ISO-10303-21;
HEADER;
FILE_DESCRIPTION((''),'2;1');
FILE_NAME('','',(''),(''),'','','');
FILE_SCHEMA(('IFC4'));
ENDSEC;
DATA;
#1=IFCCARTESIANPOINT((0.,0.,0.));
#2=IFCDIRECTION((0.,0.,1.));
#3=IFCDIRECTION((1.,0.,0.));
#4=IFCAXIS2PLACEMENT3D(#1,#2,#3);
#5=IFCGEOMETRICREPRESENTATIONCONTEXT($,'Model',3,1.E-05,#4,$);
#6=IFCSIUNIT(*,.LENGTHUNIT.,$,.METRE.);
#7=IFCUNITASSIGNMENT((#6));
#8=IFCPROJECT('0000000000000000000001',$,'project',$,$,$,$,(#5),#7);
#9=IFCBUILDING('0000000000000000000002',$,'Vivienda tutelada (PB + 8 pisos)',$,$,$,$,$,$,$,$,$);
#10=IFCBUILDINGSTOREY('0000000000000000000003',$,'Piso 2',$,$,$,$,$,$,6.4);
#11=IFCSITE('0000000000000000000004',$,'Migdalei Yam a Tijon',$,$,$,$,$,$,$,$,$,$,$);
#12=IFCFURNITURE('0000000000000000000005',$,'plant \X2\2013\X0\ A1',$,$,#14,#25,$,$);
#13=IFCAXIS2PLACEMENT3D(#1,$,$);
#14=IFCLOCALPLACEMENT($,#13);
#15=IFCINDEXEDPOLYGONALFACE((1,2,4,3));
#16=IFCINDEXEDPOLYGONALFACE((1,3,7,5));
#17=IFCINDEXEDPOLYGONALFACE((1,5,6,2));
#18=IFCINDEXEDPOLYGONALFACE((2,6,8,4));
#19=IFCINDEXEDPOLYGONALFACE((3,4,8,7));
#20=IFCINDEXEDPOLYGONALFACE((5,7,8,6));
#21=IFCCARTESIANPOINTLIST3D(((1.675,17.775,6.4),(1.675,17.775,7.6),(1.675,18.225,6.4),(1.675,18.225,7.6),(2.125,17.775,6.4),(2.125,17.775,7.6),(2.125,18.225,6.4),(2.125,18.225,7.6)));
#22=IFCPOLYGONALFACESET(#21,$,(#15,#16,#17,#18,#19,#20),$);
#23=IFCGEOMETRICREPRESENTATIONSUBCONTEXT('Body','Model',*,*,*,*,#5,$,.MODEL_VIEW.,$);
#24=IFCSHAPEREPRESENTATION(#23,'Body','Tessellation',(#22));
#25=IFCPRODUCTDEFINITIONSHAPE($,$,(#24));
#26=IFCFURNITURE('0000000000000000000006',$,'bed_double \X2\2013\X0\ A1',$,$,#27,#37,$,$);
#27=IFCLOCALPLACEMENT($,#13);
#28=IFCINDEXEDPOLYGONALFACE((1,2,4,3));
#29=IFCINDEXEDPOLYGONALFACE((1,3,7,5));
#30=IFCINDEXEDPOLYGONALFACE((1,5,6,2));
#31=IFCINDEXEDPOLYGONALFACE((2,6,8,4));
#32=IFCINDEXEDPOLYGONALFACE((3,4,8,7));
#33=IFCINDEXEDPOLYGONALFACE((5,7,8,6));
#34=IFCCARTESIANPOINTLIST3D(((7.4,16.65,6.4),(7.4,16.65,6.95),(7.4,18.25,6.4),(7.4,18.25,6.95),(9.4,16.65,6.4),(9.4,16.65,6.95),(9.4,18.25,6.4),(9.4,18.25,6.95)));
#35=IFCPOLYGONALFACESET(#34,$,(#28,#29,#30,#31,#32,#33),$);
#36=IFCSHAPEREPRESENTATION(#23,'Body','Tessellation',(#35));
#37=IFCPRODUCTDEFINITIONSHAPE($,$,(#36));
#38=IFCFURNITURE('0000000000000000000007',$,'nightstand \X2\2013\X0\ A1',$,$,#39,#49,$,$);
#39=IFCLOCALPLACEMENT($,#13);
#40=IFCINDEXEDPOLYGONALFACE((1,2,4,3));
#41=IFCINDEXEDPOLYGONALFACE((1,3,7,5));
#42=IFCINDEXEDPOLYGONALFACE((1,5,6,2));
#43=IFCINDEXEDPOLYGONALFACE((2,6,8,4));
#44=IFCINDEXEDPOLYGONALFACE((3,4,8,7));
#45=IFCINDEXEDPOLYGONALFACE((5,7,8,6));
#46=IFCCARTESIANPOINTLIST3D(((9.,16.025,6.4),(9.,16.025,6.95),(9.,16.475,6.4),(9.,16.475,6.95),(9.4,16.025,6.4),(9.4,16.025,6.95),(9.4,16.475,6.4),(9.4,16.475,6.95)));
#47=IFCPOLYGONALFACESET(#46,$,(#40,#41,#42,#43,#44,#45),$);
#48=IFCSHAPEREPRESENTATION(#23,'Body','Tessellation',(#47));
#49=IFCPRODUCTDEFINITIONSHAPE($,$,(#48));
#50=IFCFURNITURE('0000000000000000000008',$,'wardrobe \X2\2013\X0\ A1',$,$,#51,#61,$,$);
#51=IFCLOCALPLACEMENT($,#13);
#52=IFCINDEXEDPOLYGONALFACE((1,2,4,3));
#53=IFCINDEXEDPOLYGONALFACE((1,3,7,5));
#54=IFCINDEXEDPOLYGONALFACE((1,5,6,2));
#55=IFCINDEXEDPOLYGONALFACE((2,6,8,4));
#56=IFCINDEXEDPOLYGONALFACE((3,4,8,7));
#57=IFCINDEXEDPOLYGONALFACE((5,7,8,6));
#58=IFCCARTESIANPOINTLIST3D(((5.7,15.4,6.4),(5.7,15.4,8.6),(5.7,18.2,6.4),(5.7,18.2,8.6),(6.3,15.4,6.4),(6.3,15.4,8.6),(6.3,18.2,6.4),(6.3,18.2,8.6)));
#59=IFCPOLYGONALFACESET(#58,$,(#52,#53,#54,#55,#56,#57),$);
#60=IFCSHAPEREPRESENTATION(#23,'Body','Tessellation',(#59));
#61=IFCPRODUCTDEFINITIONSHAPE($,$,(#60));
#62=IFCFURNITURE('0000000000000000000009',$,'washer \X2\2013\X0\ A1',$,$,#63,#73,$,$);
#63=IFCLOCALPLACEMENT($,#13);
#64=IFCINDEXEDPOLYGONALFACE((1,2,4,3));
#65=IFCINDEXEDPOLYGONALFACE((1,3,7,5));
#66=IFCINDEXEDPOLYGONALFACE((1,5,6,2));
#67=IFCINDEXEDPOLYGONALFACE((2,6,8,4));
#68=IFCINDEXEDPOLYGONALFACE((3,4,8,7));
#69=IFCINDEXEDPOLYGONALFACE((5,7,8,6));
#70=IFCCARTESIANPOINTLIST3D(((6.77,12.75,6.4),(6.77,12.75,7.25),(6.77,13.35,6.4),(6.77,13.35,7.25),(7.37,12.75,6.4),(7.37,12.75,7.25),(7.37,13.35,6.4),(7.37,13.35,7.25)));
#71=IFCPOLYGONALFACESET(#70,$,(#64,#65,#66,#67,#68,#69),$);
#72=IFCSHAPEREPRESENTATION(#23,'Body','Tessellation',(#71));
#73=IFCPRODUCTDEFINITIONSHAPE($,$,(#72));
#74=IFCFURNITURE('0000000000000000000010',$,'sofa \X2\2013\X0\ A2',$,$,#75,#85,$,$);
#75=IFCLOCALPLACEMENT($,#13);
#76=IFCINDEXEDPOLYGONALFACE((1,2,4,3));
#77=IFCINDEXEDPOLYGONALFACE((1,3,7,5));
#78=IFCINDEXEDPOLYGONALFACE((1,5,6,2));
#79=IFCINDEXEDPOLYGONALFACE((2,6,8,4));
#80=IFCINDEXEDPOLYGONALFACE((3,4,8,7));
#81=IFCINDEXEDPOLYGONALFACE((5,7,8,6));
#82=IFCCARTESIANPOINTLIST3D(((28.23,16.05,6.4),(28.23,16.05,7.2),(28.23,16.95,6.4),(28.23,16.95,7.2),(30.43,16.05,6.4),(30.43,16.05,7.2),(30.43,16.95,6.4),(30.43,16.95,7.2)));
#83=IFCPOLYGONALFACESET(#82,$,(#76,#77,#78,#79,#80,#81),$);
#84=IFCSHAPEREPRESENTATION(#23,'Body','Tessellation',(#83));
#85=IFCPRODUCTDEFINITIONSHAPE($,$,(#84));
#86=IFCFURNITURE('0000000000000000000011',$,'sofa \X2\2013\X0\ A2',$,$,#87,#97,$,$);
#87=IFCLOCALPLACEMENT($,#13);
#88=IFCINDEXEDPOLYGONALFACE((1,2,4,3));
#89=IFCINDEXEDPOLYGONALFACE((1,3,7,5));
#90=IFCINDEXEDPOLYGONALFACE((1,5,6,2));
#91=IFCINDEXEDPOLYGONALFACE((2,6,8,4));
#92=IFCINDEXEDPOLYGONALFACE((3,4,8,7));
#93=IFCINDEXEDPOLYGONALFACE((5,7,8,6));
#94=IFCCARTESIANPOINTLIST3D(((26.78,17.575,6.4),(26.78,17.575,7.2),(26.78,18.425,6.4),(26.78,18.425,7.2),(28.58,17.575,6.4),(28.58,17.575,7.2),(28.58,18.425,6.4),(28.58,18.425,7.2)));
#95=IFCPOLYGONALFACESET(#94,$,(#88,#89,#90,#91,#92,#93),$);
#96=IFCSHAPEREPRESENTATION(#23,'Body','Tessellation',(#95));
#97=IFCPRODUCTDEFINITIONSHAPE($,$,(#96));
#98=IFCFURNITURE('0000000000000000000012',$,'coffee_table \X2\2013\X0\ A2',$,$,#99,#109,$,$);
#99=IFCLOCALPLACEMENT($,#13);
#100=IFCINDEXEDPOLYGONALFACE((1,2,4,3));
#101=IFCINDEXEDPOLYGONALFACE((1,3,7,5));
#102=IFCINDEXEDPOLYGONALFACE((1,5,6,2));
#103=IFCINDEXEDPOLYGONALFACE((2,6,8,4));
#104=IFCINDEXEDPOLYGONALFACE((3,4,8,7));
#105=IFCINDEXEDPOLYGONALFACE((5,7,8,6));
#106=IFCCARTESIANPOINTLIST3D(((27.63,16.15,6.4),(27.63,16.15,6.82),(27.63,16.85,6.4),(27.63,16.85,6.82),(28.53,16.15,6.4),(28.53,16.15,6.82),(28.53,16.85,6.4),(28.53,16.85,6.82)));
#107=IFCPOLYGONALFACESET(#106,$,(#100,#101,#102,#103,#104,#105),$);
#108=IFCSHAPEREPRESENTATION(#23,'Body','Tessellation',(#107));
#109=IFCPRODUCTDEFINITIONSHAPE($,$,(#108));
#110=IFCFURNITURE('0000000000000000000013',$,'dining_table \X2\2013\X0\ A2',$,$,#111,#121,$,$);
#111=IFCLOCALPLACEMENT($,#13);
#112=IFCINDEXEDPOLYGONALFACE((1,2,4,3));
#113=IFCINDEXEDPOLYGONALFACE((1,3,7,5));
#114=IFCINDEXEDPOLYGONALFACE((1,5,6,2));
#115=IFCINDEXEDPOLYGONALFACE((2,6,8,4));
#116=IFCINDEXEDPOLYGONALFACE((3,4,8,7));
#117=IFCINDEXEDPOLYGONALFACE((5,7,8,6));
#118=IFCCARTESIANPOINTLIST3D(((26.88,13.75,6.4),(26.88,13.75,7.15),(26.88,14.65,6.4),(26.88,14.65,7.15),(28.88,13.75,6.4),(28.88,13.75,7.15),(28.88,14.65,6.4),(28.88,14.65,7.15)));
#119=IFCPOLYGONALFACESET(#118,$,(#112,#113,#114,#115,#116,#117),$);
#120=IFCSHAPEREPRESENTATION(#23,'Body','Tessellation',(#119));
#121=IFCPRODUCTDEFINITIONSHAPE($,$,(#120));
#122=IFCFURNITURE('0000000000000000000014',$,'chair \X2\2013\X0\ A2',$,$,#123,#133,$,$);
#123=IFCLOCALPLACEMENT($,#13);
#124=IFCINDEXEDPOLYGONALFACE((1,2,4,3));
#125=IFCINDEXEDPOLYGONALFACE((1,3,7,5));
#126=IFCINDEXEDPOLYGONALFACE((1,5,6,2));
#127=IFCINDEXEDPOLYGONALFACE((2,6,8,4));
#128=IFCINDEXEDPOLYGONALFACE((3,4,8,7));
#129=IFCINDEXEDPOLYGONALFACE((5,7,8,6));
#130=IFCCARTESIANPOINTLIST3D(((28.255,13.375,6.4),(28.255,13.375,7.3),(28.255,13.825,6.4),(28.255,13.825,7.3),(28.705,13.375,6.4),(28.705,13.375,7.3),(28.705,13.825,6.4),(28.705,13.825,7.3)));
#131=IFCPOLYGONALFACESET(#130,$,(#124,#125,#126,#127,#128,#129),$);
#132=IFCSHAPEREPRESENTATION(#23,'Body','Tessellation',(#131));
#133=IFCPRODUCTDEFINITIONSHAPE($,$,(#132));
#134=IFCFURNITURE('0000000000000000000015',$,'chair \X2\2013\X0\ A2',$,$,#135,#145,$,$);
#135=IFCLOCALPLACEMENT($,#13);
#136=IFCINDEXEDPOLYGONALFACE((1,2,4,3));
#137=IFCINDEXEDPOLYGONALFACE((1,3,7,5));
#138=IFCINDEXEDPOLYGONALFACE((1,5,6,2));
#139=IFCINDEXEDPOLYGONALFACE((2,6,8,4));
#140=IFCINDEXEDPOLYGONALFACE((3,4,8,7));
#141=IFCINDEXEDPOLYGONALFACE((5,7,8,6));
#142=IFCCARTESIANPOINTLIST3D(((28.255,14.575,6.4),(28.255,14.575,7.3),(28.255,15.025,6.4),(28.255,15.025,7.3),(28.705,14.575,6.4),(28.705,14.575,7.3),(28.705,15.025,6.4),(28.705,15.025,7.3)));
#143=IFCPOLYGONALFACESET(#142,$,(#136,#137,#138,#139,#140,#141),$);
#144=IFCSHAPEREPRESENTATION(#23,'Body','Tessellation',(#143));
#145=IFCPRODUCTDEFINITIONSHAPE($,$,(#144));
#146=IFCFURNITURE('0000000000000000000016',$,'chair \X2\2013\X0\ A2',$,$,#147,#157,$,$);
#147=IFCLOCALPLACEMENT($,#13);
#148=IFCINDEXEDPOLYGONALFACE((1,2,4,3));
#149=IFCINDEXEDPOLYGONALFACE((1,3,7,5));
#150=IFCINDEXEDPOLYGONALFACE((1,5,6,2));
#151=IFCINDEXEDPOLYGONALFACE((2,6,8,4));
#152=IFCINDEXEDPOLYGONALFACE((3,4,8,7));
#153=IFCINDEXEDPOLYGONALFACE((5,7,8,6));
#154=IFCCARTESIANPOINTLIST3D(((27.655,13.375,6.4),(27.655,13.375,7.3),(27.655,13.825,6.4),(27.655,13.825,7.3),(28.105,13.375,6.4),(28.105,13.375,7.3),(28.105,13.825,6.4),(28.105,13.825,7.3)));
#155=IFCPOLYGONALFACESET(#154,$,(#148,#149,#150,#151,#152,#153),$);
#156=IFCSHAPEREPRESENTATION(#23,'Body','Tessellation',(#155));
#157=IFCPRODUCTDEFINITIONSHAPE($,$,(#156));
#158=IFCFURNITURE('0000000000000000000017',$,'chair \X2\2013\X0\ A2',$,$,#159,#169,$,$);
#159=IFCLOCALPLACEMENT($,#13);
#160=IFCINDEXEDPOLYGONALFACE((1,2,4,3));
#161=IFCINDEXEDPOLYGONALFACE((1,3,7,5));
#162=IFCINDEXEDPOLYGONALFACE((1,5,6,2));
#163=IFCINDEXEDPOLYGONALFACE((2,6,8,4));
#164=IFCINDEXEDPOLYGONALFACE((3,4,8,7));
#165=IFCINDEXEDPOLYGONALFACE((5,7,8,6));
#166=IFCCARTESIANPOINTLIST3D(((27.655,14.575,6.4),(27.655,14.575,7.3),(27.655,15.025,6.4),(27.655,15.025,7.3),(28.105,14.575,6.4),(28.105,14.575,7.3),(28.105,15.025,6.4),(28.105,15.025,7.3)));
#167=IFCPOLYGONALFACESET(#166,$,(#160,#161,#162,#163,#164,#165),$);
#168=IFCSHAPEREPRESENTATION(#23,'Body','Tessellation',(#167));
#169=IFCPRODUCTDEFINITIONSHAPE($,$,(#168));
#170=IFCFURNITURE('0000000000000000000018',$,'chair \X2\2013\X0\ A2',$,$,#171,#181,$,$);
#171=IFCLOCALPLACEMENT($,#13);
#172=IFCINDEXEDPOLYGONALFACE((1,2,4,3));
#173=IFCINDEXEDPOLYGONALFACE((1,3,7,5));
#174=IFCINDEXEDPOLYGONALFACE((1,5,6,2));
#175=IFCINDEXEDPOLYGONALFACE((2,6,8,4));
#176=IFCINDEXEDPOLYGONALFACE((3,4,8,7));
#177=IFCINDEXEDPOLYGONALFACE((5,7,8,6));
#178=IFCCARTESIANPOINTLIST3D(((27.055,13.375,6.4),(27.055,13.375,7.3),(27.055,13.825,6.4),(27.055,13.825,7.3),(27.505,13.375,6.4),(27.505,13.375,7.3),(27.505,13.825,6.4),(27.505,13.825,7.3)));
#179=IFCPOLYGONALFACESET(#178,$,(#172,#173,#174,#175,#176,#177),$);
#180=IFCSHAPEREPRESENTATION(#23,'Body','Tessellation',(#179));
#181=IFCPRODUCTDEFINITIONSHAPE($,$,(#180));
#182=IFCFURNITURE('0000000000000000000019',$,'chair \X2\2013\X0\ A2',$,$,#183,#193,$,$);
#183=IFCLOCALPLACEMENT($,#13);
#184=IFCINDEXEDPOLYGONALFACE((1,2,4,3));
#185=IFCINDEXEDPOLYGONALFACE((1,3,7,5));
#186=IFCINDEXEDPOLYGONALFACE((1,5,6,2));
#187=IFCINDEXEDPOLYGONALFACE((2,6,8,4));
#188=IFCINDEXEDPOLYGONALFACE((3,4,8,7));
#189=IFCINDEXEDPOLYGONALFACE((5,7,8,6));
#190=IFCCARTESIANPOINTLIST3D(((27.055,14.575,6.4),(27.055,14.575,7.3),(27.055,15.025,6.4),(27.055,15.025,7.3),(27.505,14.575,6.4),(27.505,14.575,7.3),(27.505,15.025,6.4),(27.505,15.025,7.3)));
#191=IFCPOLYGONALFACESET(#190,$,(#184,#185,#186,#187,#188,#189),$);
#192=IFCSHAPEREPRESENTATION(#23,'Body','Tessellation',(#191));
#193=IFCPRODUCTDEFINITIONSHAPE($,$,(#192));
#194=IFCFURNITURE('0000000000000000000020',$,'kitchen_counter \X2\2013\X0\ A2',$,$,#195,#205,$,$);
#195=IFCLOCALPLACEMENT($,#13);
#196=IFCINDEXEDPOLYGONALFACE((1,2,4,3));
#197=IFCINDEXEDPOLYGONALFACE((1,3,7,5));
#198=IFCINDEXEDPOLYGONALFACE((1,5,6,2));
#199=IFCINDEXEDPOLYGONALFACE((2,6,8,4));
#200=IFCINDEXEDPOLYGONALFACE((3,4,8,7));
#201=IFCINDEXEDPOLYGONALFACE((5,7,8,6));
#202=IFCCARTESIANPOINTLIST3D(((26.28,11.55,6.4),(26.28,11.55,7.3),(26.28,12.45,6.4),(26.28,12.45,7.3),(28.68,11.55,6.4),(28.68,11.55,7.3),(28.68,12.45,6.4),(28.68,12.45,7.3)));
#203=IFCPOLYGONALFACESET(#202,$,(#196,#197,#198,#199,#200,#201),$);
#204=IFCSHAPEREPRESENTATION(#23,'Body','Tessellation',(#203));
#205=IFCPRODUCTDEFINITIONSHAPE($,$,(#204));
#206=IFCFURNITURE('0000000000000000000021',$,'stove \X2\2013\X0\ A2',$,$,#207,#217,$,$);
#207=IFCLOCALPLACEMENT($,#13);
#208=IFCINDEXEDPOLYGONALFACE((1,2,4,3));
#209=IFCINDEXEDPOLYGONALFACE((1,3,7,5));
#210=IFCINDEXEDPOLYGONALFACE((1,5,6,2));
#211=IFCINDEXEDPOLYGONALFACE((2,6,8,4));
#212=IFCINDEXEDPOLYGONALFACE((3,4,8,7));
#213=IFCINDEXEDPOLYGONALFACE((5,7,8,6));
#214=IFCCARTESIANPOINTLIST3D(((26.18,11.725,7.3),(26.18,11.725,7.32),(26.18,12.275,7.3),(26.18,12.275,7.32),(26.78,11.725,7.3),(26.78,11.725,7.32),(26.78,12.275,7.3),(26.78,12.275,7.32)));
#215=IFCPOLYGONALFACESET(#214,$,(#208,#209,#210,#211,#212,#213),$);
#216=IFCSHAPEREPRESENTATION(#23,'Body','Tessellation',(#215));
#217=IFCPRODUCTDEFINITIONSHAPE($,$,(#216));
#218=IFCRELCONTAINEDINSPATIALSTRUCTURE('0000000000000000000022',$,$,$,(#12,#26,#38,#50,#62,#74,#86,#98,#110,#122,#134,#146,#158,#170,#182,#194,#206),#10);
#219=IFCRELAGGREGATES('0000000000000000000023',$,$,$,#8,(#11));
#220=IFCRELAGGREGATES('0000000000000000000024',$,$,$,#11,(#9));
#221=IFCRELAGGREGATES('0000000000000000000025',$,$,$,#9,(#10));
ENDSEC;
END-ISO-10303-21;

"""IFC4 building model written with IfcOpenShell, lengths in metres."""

from ifc_helpers import new_model, si_unit, frame, origin_with_axes, context, subcontext, project, spatial, line, indexed_curve, outline, extrude, element, save


model = new_model("IFC4")

# Units and contexts
model_context = context("Model", 3, precision=1e-05, world=origin_with_axes())
body_context = subcontext(model_context, "Body", "Model", "MODEL_VIEW")
ifc_project = project(units=[si_unit("LENGTHUNIT", "METRE")], contexts=[model_context])

# Site, building, storey
site = spatial("IfcSite", under=ifc_project, Name="Migdalei Yam a Tijon")
building = spatial("IfcBuilding", under=site, Name="Vivienda tutelada (PB + 8 pisos)")
storey = spatial("IfcBuildingStorey", under=building, Name="Piso 2", Elevation=6.4)

# Furniture
element("IfcFurniture", 1, inside=storey, Name="plant – A1", context=body_context, shape_type="SweptSolid", body=[
    extrude(outline(indexed_curve([(0.0, 0.0), (0.45, 0.0), (0.45, 0.45), (0.0, 0.45)], segments=[line(1, 2, 3, 4, 1)])), frame((1.675, 17.775, 6.4), z_axis=(0.0, 0.0, 1.0), x_axis=(1.0, 0.0, 0.0)), (0.0, 0.0, 1.0), 1.2),
])
element("IfcFurniture", 2, inside=storey, Name="bed_double – A1", context=body_context, shape_type="SweptSolid", body=[
    extrude(outline(indexed_curve([(0.0, 0.0), (2.0, 0.0), (2.0, 1.6), (0.0, 1.6)], segments=[line(1, 2, 3, 4, 1)])), frame((7.4, 16.65, 6.4), z_axis=(0.0, 0.0, 1.0), x_axis=(1.0, 0.0, 0.0)), (0.0, 0.0, 1.0), 0.55),
])
element("IfcFurniture", 3, inside=storey, Name="nightstand – A1", context=body_context, shape_type="SweptSolid", body=[
    extrude(outline(indexed_curve([(0.0, 0.0), (0.4, 0.0), (0.4, 0.45), (0.0, 0.45)], segments=[line(1, 2, 3, 4, 1)])), frame((9.0, 16.025, 6.4), z_axis=(0.0, 0.0, 1.0), x_axis=(1.0, 0.0, 0.0)), (0.0, 0.0, 1.0), 0.55),
])
element("IfcFurniture", 4, inside=storey, Name="wardrobe – A1", context=body_context, shape_type="SweptSolid", body=[
    extrude(outline(indexed_curve([(0.0, 0.0), (0.6, 0.0), (0.6, 2.8), (0.0, 2.8)], segments=[line(1, 2, 3, 4, 1)])), frame((5.7, 15.4, 6.4), z_axis=(0.0, 0.0, 1.0), x_axis=(1.0, 0.0, 0.0)), (0.0, 0.0, 1.0), 2.2),
])
element("IfcFurniture", 5, inside=storey, Name="washer – A1", context=body_context, shape_type="SweptSolid", body=[
    extrude(outline(indexed_curve([(0.0, 0.0), (0.6, 0.0), (0.6, 0.6), (0.0, 0.6)], segments=[line(1, 2, 3, 4, 1)])), frame((6.77, 12.75, 6.4), z_axis=(0.0, 0.0, 1.0), x_axis=(1.0, 0.0, 0.0)), (0.0, 0.0, 1.0), 0.85),
])
element("IfcFurniture", 6, inside=storey, Name="sofa – A2", context=body_context, shape_type="SweptSolid", body=[
    extrude(outline(indexed_curve([(0.0, 0.0), (2.2, 0.0), (2.2, 0.9), (0.0, 0.9)], segments=[line(1, 2, 3, 4, 1)])), frame((28.23, 16.05, 6.4), z_axis=(0.0, 0.0, 1.0), x_axis=(1.0, 0.0, 0.0)), (0.0, 0.0, 1.0), 0.8),
])
element("IfcFurniture", 7, inside=storey, Name="sofa – A2", context=body_context, shape_type="SweptSolid", body=[
    extrude(outline(indexed_curve([(0.0, 0.0), (1.8, 0.0), (1.8, 0.85), (0.0, 0.85)], segments=[line(1, 2, 3, 4, 1)])), frame((26.78, 17.575, 6.4), z_axis=(0.0, 0.0, 1.0), x_axis=(1.0, 0.0, 0.0)), (0.0, 0.0, 1.0), 0.8),
])
element("IfcFurniture", 8, inside=storey, Name="coffee_table – A2", context=body_context, shape_type="SweptSolid", body=[
    extrude(outline(indexed_curve([(0.0, 0.0), (0.9, 0.0), (0.9, 0.7), (0.0, 0.7)], segments=[line(1, 2, 3, 4, 1)])), frame((27.63, 16.15, 6.4), z_axis=(0.0, 0.0, 1.0), x_axis=(1.0, 0.0, 0.0)), (0.0, 0.0, 1.0), 0.42),
])
element("IfcFurniture", 9, inside=storey, Name="dining_table – A2", context=body_context, shape_type="SweptSolid", body=[
    extrude(outline(indexed_curve([(0.0, 0.0), (2.0, 0.0), (2.0, 0.9), (0.0, 0.9)], segments=[line(1, 2, 3, 4, 1)])), frame((26.88, 13.75, 6.4), z_axis=(0.0, 0.0, 1.0), x_axis=(1.0, 0.0, 0.0)), (0.0, 0.0, 1.0), 0.75),
])
element("IfcFurniture", 10, inside=storey, Name="chair – A2", context=body_context, shape_type="SweptSolid", body=[
    extrude(outline(indexed_curve([(0.0, 0.0), (0.45, 0.0), (0.45, 0.45), (0.0, 0.45)], segments=[line(1, 2, 3, 4, 1)])), frame((28.255, 13.375, 6.4), z_axis=(0.0, 0.0, 1.0), x_axis=(1.0, 0.0, 0.0)), (0.0, 0.0, 1.0), 0.9),
])
element("IfcFurniture", 11, inside=storey, Name="chair – A2", context=body_context, shape_type="SweptSolid", body=[
    extrude(outline(indexed_curve([(0.0, 0.0), (0.45, 0.0), (0.45, 0.45), (0.0, 0.45)], segments=[line(1, 2, 3, 4, 1)])), frame((28.255, 14.575, 6.4), z_axis=(0.0, 0.0, 1.0), x_axis=(1.0, 0.0, 0.0)), (0.0, 0.0, 1.0), 0.9),
])
element("IfcFurniture", 12, inside=storey, Name="chair – A2", context=body_context, shape_type="SweptSolid", body=[
    extrude(outline(indexed_curve([(0.0, 0.0), (0.45, 0.0), (0.45, 0.45), (0.0, 0.45)], segments=[line(1, 2, 3, 4, 1)])), frame((27.655, 13.375, 6.4), z_axis=(0.0, 0.0, 1.0), x_axis=(1.0, 0.0, 0.0)), (0.0, 0.0, 1.0), 0.9),
])
element("IfcFurniture", 13, inside=storey, Name="chair – A2", context=body_context, shape_type="SweptSolid", body=[
    extrude(outline(indexed_curve([(0.0, 0.0), (0.45, 0.0), (0.45, 0.45), (0.0, 0.45)], segments=[line(1, 2, 3, 4, 1)])), frame((27.655, 14.575, 6.4), z_axis=(0.0, 0.0, 1.0), x_axis=(1.0, 0.0, 0.0)), (0.0, 0.0, 1.0), 0.9),
])
element("IfcFurniture", 14, inside=storey, Name="chair – A2", context=body_context, shape_type="SweptSolid", body=[
    extrude(outline(indexed_curve([(0.0, 0.0), (0.45, 0.0), (0.45, 0.45), (0.0, 0.45)], segments=[line(1, 2, 3, 4, 1)])), frame((27.055, 13.375, 6.4), z_axis=(0.0, 0.0, 1.0), x_axis=(1.0, 0.0, 0.0)), (0.0, 0.0, 1.0), 0.9),
])
element("IfcFurniture", 15, inside=storey, Name="chair – A2", context=body_context, shape_type="SweptSolid", body=[
    extrude(outline(indexed_curve([(0.0, 0.0), (0.45, 0.0), (0.45, 0.45), (0.0, 0.45)], segments=[line(1, 2, 3, 4, 1)])), frame((27.055, 14.575, 6.4), z_axis=(0.0, 0.0, 1.0), x_axis=(1.0, 0.0, 0.0)), (0.0, 0.0, 1.0), 0.9),
])
element("IfcFurniture", 16, inside=storey, Name="kitchen_counter – A2", context=body_context, shape_type="SweptSolid", body=[
    extrude(outline(indexed_curve([(0.0, 0.0), (2.4, 0.0), (2.4, 0.9), (0.0, 0.9)], segments=[line(1, 2, 3, 4, 1)])), frame((26.28, 11.55, 6.4), z_axis=(0.0, 0.0, 1.0), x_axis=(1.0, 0.0, 0.0)), (0.0, 0.0, 1.0), 0.9),
])
element("IfcFurniture", 17, inside=storey, Name="stove – A2", context=body_context, shape_type="SweptSolid", body=[
    extrude(outline(indexed_curve([(0.0, 0.0), (0.6, 0.0), (0.6, 0.55), (0.0, 0.55)], segments=[line(1, 2, 3, 4, 1)])), frame((26.18, 11.725, 7.3), z_axis=(0.0, 0.0, 1.0), x_axis=(1.0, 0.0, 0.0)), (0.0, 0.0, 1.0), 0.02),
])

save(model, "model.ifc")
